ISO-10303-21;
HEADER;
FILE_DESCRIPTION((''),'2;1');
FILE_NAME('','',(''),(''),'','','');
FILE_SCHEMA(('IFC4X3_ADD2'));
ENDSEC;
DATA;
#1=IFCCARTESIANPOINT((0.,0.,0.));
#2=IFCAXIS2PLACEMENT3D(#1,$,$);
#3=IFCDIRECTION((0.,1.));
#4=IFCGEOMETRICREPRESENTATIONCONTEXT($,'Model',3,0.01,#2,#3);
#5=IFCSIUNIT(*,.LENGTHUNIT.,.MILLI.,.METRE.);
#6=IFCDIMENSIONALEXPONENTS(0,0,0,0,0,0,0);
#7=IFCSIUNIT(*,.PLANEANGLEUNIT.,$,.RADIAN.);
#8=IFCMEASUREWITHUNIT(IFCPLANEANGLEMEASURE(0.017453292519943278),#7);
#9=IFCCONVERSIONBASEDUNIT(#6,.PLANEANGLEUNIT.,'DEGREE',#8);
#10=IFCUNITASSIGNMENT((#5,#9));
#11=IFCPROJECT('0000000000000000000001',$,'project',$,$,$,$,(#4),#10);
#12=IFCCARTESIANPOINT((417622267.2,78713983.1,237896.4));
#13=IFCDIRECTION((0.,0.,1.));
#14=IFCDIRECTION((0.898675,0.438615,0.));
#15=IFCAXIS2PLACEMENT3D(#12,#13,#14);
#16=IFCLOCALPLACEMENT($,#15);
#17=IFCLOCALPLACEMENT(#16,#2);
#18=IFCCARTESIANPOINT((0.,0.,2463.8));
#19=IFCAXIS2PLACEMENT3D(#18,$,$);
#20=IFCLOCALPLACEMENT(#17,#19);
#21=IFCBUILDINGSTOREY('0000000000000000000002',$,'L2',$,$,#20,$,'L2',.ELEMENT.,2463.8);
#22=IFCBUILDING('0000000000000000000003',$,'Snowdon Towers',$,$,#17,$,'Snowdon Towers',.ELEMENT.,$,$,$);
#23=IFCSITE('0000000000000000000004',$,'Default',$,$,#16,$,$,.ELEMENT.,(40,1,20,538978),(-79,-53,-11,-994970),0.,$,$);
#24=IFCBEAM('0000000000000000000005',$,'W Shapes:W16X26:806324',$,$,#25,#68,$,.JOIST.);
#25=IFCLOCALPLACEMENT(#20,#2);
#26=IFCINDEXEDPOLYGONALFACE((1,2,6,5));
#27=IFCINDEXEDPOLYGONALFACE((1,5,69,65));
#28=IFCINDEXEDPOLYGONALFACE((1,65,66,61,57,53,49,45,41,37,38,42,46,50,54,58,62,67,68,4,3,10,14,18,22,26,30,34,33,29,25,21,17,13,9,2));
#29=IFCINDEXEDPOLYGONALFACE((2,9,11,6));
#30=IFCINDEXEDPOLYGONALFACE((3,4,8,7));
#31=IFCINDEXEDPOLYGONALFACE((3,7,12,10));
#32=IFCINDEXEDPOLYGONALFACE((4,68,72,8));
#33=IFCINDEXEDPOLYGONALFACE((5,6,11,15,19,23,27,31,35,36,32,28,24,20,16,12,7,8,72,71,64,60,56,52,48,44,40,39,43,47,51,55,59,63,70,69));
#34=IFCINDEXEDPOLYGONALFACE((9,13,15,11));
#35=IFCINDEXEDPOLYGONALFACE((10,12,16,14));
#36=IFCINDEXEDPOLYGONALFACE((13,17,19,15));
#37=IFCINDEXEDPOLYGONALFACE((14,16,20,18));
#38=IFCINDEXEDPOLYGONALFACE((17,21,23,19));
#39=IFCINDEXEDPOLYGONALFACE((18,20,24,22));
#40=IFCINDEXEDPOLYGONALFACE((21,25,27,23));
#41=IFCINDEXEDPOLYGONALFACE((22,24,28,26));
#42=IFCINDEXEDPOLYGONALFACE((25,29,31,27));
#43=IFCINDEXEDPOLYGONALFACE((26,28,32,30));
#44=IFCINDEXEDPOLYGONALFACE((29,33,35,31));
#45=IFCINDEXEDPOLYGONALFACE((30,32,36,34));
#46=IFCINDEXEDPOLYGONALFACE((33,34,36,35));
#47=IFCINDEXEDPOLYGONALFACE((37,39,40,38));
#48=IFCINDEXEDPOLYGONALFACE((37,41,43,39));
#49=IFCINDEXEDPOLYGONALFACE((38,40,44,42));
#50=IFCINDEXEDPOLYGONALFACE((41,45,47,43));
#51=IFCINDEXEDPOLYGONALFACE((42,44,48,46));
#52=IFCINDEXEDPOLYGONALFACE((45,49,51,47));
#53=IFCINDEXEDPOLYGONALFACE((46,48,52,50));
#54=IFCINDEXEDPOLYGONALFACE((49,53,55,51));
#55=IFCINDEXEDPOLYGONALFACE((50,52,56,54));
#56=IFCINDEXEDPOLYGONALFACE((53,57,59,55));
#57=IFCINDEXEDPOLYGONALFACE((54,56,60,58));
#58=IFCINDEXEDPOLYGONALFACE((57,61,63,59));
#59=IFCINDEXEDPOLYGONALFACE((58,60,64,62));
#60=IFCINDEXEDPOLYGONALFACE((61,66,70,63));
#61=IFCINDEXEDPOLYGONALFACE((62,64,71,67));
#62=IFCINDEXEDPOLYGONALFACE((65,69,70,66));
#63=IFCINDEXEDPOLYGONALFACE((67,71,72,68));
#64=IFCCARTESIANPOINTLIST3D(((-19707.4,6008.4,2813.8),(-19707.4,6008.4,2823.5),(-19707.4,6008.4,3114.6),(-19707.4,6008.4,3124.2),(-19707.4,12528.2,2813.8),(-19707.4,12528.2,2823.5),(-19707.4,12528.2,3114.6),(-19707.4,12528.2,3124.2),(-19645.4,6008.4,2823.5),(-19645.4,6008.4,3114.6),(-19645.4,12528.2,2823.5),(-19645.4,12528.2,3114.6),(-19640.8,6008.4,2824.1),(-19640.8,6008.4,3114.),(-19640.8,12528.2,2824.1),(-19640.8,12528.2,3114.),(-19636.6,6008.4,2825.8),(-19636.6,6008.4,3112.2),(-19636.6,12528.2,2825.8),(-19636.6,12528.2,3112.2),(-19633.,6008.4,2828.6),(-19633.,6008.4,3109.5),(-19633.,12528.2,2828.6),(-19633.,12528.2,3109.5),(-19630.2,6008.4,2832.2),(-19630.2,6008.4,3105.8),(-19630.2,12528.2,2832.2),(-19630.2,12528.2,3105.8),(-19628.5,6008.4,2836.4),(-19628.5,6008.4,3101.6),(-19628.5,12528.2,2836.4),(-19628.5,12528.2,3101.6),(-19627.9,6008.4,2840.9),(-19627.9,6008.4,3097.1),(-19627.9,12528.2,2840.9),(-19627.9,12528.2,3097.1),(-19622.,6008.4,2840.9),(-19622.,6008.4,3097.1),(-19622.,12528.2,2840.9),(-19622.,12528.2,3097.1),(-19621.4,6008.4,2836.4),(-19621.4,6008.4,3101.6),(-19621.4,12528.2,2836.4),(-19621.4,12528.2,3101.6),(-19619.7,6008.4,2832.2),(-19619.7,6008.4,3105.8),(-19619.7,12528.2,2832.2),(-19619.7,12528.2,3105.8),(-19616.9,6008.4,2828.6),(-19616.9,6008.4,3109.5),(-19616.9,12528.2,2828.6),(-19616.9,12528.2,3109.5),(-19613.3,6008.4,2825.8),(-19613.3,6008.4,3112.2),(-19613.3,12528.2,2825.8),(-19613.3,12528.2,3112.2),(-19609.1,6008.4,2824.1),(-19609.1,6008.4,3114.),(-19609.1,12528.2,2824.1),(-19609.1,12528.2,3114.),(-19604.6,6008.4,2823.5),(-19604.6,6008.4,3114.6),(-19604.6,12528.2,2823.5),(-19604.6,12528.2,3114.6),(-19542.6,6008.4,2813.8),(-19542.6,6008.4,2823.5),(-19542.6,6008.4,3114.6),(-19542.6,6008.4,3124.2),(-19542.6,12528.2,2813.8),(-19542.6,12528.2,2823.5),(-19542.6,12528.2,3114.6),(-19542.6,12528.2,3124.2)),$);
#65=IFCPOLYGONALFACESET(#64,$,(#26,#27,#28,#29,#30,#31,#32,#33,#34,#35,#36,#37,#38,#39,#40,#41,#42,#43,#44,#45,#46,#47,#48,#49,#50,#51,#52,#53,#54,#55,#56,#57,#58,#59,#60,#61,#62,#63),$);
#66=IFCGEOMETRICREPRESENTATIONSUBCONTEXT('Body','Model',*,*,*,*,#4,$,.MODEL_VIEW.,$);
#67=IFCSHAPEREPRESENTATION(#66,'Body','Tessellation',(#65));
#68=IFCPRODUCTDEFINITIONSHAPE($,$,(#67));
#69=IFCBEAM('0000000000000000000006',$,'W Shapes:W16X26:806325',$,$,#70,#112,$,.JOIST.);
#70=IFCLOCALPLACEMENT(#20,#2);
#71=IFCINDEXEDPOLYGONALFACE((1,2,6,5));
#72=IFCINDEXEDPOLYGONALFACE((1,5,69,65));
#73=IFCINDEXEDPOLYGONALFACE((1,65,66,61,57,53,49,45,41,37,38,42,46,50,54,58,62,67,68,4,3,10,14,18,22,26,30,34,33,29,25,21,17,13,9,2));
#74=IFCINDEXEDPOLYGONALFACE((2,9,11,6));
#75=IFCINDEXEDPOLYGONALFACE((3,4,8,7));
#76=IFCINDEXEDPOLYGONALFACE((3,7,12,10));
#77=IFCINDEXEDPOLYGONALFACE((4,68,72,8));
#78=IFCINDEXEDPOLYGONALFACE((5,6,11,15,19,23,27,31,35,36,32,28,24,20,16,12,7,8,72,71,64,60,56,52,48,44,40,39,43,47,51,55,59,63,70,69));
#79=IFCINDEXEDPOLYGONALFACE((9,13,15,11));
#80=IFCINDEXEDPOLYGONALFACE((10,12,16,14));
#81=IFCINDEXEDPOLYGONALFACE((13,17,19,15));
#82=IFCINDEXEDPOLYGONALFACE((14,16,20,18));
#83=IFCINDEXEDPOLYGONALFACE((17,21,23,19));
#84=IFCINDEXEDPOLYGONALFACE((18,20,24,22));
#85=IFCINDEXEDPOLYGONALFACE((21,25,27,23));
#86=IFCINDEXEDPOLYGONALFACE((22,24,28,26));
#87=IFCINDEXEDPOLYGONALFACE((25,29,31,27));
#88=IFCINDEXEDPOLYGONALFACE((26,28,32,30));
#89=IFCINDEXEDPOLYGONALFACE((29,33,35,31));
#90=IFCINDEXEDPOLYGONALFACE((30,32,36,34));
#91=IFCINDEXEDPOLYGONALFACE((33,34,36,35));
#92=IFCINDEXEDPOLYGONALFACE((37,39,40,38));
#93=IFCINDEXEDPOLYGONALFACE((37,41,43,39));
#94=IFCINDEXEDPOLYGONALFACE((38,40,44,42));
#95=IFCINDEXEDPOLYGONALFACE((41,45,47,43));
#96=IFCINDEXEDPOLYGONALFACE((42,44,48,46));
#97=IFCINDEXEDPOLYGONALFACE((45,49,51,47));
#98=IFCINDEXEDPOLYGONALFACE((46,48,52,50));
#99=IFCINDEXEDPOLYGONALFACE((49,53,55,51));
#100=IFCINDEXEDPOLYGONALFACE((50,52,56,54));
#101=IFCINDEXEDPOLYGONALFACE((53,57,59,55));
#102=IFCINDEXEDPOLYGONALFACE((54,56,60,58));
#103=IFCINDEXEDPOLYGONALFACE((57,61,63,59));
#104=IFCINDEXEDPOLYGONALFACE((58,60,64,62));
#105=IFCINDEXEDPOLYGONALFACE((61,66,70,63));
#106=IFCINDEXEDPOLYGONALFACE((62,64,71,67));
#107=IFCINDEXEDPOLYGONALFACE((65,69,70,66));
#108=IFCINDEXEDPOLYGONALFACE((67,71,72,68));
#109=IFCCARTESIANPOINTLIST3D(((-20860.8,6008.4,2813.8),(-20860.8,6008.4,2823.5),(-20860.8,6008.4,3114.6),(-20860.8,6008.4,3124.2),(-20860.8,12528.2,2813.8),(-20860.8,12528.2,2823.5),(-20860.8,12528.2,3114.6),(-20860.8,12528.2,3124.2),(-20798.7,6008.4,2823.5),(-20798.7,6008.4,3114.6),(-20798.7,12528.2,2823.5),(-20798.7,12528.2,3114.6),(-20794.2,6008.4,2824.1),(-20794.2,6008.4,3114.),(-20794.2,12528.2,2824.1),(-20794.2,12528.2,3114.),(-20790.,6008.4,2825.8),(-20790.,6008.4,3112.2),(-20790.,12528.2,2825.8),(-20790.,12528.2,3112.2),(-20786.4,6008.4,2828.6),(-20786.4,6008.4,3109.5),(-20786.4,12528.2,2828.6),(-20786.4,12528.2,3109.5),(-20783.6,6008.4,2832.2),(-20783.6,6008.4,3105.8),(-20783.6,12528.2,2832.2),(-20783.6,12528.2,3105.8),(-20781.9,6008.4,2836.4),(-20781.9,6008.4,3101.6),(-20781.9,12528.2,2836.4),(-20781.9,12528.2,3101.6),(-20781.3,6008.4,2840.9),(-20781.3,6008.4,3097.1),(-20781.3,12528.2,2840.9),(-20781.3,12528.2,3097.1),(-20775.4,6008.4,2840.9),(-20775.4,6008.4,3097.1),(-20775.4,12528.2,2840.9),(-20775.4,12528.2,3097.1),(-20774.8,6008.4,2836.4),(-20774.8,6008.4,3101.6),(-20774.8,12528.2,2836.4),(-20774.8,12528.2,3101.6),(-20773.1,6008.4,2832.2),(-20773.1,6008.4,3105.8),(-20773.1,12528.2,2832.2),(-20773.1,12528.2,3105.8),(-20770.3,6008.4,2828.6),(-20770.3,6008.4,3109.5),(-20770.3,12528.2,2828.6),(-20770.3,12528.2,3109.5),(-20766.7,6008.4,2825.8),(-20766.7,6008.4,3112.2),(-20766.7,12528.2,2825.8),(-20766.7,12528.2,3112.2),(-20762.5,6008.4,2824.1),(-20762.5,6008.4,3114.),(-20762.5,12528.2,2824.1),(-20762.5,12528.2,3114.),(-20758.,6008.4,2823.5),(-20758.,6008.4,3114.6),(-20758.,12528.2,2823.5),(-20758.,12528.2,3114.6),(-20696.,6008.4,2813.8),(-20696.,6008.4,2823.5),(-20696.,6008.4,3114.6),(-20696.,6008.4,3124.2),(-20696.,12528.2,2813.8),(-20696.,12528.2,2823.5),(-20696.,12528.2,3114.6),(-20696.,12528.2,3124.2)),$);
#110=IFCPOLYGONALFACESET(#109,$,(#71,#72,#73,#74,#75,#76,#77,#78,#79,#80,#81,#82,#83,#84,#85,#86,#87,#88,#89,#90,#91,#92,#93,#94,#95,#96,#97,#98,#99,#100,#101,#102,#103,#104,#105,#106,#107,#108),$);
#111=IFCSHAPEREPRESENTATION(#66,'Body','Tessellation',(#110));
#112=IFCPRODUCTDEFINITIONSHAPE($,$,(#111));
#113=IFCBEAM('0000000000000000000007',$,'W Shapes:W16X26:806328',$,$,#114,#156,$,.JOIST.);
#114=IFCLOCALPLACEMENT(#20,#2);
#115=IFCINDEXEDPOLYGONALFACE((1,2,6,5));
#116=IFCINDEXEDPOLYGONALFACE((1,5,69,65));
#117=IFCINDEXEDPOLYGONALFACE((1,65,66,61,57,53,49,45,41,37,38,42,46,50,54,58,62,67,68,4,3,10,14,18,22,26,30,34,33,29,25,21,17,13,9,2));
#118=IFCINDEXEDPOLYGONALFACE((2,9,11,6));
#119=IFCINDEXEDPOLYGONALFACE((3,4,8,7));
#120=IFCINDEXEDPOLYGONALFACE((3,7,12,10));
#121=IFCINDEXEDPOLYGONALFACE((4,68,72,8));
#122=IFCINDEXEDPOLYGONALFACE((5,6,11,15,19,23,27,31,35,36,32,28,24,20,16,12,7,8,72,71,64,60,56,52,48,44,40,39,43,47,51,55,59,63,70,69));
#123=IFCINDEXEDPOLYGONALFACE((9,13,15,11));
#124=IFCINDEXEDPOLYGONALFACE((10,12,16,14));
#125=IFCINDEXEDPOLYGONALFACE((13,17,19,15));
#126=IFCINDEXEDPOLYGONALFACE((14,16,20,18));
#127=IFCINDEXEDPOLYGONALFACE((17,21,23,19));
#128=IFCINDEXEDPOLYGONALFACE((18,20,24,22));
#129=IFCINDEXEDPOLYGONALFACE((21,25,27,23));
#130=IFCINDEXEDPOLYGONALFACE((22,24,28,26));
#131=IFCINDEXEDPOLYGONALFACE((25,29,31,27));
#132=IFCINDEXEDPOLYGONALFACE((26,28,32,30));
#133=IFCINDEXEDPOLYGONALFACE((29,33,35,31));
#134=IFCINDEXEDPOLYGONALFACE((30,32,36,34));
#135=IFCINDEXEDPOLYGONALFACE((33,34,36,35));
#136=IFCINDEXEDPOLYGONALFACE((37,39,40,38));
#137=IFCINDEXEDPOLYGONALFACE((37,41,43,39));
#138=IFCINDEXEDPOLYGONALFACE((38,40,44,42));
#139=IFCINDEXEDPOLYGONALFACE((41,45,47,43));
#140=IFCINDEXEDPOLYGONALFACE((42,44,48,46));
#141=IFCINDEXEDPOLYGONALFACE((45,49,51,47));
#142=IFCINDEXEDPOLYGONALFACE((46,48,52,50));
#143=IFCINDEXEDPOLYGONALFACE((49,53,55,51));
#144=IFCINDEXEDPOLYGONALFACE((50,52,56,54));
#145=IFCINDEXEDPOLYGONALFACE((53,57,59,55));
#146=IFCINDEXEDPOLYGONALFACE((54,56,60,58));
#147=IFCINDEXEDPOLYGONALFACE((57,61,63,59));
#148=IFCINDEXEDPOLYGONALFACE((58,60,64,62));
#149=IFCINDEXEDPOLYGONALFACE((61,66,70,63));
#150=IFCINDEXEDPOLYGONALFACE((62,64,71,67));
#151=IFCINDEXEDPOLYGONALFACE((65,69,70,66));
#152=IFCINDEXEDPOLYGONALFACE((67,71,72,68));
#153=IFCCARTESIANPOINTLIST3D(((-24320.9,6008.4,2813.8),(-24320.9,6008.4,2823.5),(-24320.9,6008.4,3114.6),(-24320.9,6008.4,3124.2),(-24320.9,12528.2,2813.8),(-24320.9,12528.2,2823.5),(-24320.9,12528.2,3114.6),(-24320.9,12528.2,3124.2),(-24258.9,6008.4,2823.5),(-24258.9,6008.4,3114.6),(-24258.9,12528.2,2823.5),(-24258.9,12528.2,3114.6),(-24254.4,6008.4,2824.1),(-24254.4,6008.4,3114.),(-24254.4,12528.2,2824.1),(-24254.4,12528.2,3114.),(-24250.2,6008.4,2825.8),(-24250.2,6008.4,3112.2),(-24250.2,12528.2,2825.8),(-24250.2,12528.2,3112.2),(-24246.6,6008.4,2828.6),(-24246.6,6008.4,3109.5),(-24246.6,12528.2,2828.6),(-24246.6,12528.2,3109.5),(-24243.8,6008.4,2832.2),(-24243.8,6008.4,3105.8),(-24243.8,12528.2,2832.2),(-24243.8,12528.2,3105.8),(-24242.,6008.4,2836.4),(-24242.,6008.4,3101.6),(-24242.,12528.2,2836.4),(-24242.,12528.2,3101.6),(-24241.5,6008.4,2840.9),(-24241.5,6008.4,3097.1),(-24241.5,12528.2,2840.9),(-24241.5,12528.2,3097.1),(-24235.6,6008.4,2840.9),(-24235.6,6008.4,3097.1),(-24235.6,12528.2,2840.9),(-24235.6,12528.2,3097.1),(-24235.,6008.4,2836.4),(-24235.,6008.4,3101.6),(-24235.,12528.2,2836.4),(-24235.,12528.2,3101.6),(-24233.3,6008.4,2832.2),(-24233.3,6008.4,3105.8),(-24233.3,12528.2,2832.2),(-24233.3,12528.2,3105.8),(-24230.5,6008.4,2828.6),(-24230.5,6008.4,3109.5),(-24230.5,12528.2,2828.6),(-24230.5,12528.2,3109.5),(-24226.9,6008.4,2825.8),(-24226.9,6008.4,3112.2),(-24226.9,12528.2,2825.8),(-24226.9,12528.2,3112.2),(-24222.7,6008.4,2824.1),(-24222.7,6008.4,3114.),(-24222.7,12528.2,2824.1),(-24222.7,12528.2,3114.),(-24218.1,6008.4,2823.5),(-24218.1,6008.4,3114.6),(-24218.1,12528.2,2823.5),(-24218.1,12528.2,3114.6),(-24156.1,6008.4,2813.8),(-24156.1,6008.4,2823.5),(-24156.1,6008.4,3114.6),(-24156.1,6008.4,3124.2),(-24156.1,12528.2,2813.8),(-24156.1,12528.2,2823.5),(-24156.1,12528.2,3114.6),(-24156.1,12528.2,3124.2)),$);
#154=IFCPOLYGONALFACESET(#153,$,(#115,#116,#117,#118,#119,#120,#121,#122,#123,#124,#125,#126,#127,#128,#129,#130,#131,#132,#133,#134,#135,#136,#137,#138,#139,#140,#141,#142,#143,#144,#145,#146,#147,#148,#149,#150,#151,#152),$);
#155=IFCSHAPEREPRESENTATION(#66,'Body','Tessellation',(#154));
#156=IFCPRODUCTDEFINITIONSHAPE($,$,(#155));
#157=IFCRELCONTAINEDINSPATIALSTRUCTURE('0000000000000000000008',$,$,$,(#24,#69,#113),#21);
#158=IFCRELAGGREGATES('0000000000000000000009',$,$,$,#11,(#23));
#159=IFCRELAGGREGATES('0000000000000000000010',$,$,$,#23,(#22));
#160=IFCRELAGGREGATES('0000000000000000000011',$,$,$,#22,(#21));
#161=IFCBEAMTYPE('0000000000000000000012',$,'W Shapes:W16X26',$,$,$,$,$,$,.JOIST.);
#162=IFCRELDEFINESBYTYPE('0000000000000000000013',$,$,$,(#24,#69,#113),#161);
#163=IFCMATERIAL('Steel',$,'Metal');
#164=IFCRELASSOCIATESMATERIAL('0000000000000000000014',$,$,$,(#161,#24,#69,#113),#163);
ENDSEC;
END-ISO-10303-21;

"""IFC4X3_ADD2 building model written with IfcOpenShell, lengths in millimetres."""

from ifc_helpers import new_model, entity, si_unit, converted_unit, direction, frame, frame_2d, origin, place, context, subcontext, project, spatial, polyline, circle_curve, parameter, trimmed, segment, composite_curve, outline, extrude, source, transform, mapped, material, material_profile, profile_set, profile_usage, type_object, type_shapes, element, save


model = new_model("IFC4X3_ADD2")

# Units and contexts
model_context = context("Model", 3, precision=0.01, world=origin(), true_north=direction((0.0, 1.0)))
body_context = subcontext(model_context, "Body", "Model", "MODEL_VIEW")
ifc_project = project(units=[si_unit("LENGTHUNIT", "METRE", prefix="MILLI"), converted_unit("PLANEANGLEUNIT", "DEGREE", entity("IfcPlaneAngleMeasure", 0.017453292519943278), si_unit("PLANEANGLEUNIT", "RADIAN"), dimensions=[0, 0, 0, 0, 0, 0, 0])], contexts=[model_context])

# Site, building, storey
site_placement = place(None, frame((417622267.2, 78713983.1, 237896.4), z_axis=(0.0, 0.0, 1.0), x_axis=(0.898675, 0.438615, 0.0)))
site = spatial("IfcSite", under=ifc_project, at=site_placement, Name="Default", CompositionType="ELEMENT", RefLatitude=(40, 1, 20, 538978), RefLongitude=(-79, -53, -11, -994970), RefElevation=0.0)
building_placement = place(site_placement, origin())
building = spatial("IfcBuilding", under=site, at=building_placement, Name="Snowdon Towers", LongName="Snowdon Towers", CompositionType="ELEMENT")
storey_placement = place(building_placement, frame((0.0, 0.0, 2463.8)))
storey = spatial("IfcBuildingStorey", under=building, at=storey_placement, Name="L2", LongName="L2", CompositionType="ELEMENT", Elevation=2463.8)

# Beams
ifc_material_1 = material(Name="Steel", Category="Metal")
ifc_material_profile_1 = material_profile(ifc_material_1, outline(composite_curve([segment(polyline([(-82.4, -145.6), (-82.4, -155.2)]), True, "CONTINUOUS"), segment(polyline([(-82.4, -155.2), (82.4, -155.2)]), True, "CONTINUOUS"), segment(polyline([(82.4, -155.2), (82.4, -145.6)]), True, "CONTINUOUS"), segment(polyline([(82.4, -145.6), (20.4, -145.6)]), True, "CONTINUOUS"), segment(trimmed(circle_curve(frame_2d((20.4, -128.1), x_axis=(1.0, 0.0)), 17.5), [parameter(180.0)], [parameter(270.0)], True, "PARAMETER"), False, "CONTINUOUS"), segment(polyline([(2.9, -128.1), (2.9, 128.1)]), True, "CONTINUOUS"), segment(trimmed(circle_curve(frame_2d((20.4, 128.1), x_axis=(1.0, 0.0)), 17.5), [parameter(90.0)], [parameter(180.0)], True, "PARAMETER"), False, "CONTINUOUS"), segment(polyline([(20.4, 145.6), (82.4, 145.6)]), True, "CONTINUOUS"), segment(polyline([(82.4, 145.6), (82.4, 155.2)]), True, "CONTINUOUS"), segment(polyline([(82.4, 155.2), (-82.4, 155.2)]), True, "CONTINUOUS"), segment(polyline([(-82.4, 155.2), (-82.4, 145.6)]), True, "CONTINUOUS"), segment(polyline([(-82.4, 145.6), (-20.4, 145.6)]), True, "CONTINUOUS"), segment(trimmed(circle_curve(frame_2d((-20.4, 128.1), x_axis=(1.0, 0.0)), 17.5), [parameter(360.0)], [parameter(90.0)], True, "PARAMETER"), False, "CONTINUOUS"), segment(polyline([(-2.9, 128.1), (-2.9, -128.1)]), True, "CONTINUOUS"), segment(trimmed(circle_curve(frame_2d((-20.4, -128.1), x_axis=(1.0, 0.0)), 17.5), [parameter(270.0)], [parameter(360.0)], True, "PARAMETER"), False, "CONTINUOUS"), segment(polyline([(-20.4, -145.6), (-82.4, -145.6)]), True, "CONTINUOUS")], self_intersect=False)), Name="W16X26")
ifc_profile_set_1 = profile_set([ifc_material_profile_1], Name="W16X26")
ifc_profile_usage_1 = profile_usage(ifc_profile_set_1, cardinal=8)
beam_type_1 = type_object("IfcBeamType", Name="W Shapes:W16X26", PredefinedType="JOIST", material=ifc_profile_set_1)
shared_shape_1 = source(origin(), body_context, "Body", "SweptSolid", [
    extrude(outline(composite_curve([segment(polyline([(-82.4, -145.6), (-82.4, -155.2)]), True, "CONTINUOUS"), segment(polyline([(-82.4, -155.2), (82.4, -155.2)]), True, "CONTINUOUS"), segment(polyline([(82.4, -155.2), (82.4, -145.6)]), True, "CONTINUOUS"), segment(polyline([(82.4, -145.6), (20.4, -145.6)]), True, "CONTINUOUS"), segment(trimmed(circle_curve(frame_2d((20.4, -128.1), x_axis=(1.0, 0.0)), 17.5), [parameter(180.0)], [parameter(270.0)], True, "PARAMETER"), False, "CONTINUOUS"), segment(polyline([(2.9, -128.1), (2.9, 128.1)]), True, "CONTINUOUS"), segment(trimmed(circle_curve(frame_2d((20.4, 128.1), x_axis=(1.0, 0.0)), 17.5), [parameter(90.0)], [parameter(180.0)], True, "PARAMETER"), False, "CONTINUOUS"), segment(polyline([(20.4, 145.6), (82.4, 145.6)]), True, "CONTINUOUS"), segment(polyline([(82.4, 145.6), (82.4, 155.2)]), True, "CONTINUOUS"), segment(polyline([(82.4, 155.2), (-82.4, 155.2)]), True, "CONTINUOUS"), segment(polyline([(-82.4, 155.2), (-82.4, 145.6)]), True, "CONTINUOUS"), segment(polyline([(-82.4, 145.6), (-20.4, 145.6)]), True, "CONTINUOUS"), segment(trimmed(circle_curve(frame_2d((-20.4, 128.1), x_axis=(1.0, 0.0)), 17.5), [parameter(360.0)], [parameter(90.0)], True, "PARAMETER"), False, "CONTINUOUS"), segment(polyline([(-2.9, 128.1), (-2.9, -128.1)]), True, "CONTINUOUS"), segment(trimmed(circle_curve(frame_2d((-20.4, -128.1), x_axis=(1.0, 0.0)), 17.5), [parameter(270.0)], [parameter(360.0)], True, "PARAMETER"), False, "CONTINUOUS"), segment(polyline([(-20.4, -145.6), (-82.4, -145.6)]), True, "CONTINUOUS")], self_intersect=False)), frame((-3282.6, 0.0, 0.0), z_axis=(-1.0, 0.0, 0.0), x_axis=(0.0, -1.0, 0.0)), (0.0, 0.0, -1.0), 6519.8),
])
type_shapes(beam_type_1, [shared_shape_1])
for number, where, z_axis, x_axis, name in (
    (1, (-19625.0, 9245.6, 2969.0), (0.0, 0.0, 1.0), (0.0, -1.0, 0.0), "W Shapes:W16X26:806324"),
    (2, (-20778.4, 9245.6, 2969.0), (0.0, 0.0, 1.0), (0.0, -1.0, 0.0), "W Shapes:W16X26:806325"),
    (3, (-24238.5, 9245.6, 2969.0), (0.0, 0.0, 1.0), (0.0, -1.0, 0.0), "W Shapes:W16X26:806328"),
):
    element("IfcBeam", number, at=place(storey_placement, frame(where, z_axis=z_axis, x_axis=x_axis)), inside=storey, type_object=beam_type_1, material=ifc_profile_usage_1, Name=name, PredefinedType="JOIST", context=body_context, shape_type="MappedRepresentation", body=[
        mapped(shared_shape_1, transform((0.0, 0.0, 0.0), scale=1.0)),
    ])

save(model, "model.ifc")
